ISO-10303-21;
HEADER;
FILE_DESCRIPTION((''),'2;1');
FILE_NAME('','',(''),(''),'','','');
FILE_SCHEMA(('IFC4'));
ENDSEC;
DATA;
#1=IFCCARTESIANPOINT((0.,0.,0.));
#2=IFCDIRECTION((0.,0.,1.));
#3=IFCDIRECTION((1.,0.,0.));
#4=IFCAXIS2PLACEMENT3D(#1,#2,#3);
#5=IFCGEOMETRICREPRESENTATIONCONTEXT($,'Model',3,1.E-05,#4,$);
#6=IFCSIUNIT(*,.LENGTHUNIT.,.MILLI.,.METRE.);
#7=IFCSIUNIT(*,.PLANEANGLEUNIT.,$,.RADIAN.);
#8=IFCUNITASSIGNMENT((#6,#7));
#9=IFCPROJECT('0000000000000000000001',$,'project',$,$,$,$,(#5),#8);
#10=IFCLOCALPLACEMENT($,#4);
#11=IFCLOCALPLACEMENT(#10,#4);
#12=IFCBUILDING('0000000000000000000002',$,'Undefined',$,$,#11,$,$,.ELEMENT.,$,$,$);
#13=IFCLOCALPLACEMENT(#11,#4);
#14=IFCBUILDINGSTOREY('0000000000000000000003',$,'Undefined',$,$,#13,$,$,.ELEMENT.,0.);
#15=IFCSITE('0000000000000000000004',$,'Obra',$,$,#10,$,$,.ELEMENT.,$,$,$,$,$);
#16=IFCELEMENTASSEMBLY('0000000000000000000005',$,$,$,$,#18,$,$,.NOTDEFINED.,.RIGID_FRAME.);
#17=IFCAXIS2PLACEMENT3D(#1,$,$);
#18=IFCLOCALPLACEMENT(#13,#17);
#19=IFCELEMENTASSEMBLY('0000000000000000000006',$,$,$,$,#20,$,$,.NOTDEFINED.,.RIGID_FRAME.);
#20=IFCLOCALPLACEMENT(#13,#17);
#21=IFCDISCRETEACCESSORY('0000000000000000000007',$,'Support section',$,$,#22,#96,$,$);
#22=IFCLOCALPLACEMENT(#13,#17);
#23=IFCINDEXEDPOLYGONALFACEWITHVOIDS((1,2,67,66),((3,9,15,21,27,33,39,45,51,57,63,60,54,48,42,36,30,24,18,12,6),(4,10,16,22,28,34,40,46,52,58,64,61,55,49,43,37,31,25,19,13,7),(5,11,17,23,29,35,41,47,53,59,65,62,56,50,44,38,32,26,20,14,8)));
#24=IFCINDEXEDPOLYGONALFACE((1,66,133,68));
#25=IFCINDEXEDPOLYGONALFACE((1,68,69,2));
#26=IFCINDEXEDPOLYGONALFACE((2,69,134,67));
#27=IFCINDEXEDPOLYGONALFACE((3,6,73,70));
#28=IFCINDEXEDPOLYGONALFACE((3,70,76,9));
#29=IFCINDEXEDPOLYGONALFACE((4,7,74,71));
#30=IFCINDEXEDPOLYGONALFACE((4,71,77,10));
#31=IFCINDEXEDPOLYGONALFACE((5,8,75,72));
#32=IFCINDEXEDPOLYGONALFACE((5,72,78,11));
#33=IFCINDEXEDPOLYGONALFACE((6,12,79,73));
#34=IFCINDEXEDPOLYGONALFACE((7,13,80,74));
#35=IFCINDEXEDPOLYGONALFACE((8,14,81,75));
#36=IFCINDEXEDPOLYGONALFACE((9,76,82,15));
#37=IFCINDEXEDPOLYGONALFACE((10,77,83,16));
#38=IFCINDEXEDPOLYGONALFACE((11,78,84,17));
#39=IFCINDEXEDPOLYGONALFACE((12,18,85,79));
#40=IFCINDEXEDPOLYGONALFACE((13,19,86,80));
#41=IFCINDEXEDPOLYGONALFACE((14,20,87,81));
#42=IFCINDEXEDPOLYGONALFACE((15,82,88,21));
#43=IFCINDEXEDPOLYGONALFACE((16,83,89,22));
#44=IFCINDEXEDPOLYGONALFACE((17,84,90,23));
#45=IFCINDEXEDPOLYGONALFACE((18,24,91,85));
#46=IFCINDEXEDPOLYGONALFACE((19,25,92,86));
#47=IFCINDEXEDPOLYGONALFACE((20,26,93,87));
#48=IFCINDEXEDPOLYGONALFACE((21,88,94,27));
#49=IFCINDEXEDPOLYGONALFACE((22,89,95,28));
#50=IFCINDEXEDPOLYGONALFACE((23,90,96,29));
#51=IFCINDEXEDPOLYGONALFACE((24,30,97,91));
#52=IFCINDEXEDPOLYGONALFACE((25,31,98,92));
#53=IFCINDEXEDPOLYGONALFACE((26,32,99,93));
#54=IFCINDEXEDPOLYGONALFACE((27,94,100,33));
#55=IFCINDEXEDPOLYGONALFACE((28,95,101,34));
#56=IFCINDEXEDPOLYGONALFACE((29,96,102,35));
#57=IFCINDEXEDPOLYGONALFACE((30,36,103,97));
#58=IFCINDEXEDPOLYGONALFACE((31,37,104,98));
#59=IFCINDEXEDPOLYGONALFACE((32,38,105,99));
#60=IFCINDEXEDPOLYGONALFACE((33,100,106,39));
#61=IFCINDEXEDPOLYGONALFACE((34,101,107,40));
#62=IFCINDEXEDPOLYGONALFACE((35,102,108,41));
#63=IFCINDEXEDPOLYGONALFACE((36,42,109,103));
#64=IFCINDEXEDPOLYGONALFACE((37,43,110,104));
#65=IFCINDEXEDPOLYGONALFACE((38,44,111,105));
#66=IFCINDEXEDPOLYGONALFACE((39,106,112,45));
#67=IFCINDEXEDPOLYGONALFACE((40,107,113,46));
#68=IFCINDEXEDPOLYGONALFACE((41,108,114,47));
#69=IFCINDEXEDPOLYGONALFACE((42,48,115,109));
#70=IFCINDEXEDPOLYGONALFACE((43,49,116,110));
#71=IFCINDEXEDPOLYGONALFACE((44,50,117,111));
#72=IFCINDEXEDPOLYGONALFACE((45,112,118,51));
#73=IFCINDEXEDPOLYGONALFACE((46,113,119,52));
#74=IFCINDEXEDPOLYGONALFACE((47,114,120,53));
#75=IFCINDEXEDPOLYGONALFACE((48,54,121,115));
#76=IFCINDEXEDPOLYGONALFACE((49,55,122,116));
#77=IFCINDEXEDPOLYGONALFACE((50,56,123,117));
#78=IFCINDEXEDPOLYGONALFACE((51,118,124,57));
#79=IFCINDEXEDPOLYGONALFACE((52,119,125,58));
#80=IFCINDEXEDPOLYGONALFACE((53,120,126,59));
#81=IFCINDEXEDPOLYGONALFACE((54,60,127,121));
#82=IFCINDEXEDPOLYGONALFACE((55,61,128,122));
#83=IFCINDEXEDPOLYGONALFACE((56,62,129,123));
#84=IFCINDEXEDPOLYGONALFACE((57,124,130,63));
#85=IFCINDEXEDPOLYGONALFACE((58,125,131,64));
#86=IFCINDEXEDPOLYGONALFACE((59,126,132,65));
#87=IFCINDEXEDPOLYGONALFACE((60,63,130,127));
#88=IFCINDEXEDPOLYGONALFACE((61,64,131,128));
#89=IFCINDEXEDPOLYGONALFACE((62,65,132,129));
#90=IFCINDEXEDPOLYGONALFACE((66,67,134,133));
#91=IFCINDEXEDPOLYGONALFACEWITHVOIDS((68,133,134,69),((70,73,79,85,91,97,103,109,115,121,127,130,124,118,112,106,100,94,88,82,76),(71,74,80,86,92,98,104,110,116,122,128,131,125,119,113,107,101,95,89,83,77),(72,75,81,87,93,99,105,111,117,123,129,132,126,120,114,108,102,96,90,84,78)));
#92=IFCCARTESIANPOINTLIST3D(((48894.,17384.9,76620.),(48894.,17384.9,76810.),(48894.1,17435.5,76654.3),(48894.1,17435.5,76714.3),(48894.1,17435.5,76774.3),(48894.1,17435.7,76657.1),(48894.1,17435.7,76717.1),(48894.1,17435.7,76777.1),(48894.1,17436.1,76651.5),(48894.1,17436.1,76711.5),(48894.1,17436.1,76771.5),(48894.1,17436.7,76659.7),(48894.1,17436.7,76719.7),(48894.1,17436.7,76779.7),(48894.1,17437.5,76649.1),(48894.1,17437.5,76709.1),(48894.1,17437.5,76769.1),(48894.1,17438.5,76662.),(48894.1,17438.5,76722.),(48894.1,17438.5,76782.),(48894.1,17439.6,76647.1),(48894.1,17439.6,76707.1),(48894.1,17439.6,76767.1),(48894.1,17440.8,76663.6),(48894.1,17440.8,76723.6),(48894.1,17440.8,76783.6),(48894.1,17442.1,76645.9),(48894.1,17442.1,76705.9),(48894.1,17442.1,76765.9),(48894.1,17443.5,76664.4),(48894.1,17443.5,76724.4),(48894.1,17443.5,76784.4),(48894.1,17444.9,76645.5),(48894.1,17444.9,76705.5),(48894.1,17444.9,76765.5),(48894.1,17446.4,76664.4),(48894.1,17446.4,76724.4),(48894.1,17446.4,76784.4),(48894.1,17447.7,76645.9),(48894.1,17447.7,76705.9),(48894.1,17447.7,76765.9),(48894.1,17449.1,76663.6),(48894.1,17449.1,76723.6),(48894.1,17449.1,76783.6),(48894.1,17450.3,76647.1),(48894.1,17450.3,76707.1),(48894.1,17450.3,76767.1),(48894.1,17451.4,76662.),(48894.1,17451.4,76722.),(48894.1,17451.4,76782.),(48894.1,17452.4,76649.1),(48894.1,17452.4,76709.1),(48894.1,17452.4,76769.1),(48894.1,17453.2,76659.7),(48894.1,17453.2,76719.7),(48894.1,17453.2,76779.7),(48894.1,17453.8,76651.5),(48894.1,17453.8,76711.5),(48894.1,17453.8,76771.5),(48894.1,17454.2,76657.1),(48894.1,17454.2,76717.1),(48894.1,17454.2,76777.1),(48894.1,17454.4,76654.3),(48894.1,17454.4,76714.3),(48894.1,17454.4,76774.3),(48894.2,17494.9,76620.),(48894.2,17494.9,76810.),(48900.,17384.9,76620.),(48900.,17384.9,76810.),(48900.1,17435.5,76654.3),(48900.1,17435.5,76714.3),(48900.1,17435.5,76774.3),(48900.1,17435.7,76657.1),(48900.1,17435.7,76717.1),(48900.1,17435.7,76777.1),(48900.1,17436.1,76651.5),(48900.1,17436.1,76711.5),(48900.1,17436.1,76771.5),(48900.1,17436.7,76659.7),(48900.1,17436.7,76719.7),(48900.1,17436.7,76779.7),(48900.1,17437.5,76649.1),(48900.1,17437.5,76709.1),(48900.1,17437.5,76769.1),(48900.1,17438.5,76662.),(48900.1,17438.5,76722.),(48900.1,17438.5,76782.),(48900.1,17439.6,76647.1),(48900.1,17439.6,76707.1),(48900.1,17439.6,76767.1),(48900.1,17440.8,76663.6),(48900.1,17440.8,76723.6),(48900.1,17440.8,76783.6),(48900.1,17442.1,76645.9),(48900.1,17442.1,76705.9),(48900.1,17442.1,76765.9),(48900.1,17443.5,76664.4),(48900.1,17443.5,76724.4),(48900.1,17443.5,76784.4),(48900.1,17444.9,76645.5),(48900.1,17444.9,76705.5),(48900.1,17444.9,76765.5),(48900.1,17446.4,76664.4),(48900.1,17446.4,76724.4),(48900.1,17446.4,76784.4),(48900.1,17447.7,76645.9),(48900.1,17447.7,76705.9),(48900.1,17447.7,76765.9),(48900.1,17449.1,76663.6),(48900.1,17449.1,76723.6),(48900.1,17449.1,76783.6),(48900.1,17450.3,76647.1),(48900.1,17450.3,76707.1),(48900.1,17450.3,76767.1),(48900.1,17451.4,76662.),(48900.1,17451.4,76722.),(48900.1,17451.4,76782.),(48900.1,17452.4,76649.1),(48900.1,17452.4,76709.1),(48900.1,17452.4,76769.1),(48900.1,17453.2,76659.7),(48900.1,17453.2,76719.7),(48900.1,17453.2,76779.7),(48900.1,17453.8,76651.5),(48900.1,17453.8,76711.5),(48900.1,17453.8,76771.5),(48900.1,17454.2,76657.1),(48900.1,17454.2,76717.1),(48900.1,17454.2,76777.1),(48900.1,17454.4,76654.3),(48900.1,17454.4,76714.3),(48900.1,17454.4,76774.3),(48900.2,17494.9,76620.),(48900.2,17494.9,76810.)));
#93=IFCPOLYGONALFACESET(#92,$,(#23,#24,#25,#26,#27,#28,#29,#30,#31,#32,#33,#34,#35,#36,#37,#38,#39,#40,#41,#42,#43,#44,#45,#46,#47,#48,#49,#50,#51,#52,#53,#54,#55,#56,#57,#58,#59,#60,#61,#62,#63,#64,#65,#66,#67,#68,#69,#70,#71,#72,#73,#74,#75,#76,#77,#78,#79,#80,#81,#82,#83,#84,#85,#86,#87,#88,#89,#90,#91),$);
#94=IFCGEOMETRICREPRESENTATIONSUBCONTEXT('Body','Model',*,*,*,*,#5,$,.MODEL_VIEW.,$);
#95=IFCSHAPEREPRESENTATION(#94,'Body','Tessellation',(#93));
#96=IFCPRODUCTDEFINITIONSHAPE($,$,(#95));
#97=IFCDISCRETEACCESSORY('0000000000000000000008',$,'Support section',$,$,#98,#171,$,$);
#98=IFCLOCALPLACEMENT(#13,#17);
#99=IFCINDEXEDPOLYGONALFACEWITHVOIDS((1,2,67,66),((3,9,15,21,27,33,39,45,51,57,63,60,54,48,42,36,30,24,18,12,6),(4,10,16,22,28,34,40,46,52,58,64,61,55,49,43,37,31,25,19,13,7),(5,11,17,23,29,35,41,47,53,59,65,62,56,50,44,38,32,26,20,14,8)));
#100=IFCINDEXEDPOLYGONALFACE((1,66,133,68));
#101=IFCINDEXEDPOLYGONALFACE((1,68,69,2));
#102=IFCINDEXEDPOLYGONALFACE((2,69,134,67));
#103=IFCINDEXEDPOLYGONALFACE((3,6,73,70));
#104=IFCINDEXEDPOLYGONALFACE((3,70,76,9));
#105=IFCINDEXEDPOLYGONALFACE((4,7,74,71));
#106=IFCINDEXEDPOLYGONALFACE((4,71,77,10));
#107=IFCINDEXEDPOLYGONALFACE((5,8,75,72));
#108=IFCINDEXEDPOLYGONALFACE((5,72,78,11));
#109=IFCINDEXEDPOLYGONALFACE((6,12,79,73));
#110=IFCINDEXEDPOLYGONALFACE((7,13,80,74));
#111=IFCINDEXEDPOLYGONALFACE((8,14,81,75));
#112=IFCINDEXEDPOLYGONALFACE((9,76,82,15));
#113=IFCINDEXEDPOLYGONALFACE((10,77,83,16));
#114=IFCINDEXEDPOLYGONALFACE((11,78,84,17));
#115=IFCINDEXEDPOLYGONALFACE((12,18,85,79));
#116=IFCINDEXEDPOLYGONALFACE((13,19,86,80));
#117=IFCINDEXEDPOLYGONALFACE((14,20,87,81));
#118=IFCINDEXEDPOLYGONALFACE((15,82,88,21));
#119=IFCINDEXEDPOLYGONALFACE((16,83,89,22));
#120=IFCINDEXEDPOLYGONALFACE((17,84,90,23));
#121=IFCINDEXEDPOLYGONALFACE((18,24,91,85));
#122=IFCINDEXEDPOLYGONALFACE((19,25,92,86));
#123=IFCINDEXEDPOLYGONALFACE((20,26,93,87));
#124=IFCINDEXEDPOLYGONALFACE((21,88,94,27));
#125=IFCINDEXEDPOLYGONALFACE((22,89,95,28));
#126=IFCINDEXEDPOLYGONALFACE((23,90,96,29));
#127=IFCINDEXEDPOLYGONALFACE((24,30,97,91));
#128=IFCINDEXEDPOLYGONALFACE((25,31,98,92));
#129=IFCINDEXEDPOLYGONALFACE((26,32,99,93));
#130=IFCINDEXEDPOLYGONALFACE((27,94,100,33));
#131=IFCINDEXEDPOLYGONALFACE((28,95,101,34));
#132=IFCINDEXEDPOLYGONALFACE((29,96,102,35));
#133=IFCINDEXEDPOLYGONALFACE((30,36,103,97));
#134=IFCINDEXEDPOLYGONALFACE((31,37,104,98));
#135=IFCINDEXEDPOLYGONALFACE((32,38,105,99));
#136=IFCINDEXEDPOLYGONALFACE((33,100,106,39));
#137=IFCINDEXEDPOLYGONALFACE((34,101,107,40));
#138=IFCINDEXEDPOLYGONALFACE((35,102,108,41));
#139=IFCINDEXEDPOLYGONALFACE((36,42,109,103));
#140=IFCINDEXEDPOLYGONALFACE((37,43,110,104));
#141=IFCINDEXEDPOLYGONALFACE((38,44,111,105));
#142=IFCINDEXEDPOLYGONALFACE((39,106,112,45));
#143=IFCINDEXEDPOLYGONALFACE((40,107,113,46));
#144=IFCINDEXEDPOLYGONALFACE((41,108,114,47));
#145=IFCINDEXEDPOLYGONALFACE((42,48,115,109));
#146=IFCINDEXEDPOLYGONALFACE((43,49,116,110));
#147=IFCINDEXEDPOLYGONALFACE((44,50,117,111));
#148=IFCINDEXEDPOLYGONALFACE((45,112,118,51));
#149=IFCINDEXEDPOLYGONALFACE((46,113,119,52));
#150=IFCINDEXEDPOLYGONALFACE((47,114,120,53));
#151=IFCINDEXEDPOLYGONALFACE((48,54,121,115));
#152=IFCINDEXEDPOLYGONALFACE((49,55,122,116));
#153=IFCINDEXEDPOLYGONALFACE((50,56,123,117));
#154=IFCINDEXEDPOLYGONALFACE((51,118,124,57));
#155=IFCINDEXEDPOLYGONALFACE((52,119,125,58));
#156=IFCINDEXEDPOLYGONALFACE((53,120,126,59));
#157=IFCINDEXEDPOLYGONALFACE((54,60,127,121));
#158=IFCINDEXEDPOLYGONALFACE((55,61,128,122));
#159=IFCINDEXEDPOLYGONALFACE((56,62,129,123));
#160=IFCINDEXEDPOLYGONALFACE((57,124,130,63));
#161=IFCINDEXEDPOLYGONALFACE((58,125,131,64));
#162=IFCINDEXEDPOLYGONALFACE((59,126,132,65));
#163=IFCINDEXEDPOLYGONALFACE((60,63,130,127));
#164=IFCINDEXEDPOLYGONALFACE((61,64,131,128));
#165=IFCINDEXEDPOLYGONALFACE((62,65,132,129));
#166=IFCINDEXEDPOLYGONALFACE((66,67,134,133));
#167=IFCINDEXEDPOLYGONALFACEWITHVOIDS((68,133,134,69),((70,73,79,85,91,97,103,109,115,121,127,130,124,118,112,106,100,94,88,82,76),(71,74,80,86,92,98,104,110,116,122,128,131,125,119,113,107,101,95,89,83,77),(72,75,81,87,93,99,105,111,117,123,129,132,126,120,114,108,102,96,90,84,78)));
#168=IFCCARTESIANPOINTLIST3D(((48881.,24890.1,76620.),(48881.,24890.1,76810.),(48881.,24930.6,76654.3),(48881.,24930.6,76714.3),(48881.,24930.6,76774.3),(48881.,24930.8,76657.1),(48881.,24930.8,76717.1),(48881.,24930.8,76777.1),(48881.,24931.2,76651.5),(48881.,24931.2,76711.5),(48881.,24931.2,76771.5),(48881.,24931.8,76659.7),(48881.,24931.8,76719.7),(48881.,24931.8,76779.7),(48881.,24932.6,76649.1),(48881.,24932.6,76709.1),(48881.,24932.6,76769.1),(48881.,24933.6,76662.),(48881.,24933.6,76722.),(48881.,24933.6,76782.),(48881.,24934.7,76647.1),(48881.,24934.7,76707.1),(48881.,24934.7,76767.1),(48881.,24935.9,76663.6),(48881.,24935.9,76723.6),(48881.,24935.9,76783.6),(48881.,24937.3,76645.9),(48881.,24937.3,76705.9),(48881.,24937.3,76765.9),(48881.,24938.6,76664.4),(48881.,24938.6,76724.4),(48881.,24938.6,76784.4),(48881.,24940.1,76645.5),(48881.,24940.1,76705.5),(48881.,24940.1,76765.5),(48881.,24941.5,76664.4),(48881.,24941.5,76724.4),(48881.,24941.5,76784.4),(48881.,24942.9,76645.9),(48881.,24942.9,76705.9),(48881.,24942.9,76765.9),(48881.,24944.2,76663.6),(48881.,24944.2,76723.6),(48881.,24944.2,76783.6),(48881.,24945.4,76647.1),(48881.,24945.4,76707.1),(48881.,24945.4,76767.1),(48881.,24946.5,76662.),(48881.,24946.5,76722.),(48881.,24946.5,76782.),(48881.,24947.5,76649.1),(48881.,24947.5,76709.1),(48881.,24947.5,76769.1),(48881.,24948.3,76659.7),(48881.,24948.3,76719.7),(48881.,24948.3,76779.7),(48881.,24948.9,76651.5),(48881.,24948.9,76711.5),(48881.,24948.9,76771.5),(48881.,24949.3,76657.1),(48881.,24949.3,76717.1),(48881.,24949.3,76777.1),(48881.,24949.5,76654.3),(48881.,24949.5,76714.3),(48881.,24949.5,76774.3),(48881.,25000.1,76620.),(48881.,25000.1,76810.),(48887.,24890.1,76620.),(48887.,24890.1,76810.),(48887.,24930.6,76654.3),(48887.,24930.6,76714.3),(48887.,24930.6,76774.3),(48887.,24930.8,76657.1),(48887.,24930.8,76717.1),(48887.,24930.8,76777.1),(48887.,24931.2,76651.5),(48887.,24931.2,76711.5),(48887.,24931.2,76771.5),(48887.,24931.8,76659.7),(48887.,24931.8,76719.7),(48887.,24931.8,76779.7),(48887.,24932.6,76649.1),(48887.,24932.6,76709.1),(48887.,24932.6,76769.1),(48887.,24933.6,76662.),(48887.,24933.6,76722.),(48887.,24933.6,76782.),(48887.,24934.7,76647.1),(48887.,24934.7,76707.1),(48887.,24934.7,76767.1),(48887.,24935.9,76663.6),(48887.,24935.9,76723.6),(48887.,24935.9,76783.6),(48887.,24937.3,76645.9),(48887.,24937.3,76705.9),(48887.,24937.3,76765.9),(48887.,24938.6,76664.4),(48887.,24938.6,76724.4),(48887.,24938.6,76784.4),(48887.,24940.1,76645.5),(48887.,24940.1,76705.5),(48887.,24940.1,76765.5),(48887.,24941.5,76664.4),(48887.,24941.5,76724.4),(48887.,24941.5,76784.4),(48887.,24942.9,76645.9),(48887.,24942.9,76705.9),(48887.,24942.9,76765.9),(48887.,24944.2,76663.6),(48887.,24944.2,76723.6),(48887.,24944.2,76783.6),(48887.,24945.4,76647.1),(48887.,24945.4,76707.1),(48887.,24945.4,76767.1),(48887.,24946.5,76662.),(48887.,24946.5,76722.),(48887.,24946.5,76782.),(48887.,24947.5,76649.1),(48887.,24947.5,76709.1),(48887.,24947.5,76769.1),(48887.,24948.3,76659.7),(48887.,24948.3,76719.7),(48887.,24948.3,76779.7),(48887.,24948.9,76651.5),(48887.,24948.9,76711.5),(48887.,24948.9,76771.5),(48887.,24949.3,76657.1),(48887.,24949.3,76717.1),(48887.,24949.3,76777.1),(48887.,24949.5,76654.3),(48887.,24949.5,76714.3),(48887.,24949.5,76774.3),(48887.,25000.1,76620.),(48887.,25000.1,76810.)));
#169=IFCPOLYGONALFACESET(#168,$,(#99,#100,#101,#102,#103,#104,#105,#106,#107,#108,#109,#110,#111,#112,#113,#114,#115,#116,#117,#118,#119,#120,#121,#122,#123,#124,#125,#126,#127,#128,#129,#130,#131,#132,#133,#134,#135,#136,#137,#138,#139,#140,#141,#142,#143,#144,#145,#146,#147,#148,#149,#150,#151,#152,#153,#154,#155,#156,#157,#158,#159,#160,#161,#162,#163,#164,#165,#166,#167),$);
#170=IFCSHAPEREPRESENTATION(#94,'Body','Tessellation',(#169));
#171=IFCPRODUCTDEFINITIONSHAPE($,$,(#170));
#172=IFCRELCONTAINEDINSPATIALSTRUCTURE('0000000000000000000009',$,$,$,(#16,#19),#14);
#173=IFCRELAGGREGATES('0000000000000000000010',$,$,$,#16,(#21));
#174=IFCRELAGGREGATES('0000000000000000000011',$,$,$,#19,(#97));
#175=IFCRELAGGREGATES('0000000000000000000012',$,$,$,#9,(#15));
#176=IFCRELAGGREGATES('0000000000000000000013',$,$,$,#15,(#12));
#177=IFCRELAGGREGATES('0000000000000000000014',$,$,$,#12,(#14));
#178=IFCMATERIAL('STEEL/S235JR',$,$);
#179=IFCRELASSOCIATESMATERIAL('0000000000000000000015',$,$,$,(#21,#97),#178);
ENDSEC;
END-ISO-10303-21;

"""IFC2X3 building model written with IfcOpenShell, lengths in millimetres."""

from ifc_helpers import new_model, si_unit, frame, origin_with_axes, origin_2d_with_axis, place, context, subcontext, project, spatial, rectangle, circle, extrude, source, transform, mapped, material, element, aggregate, save


model = new_model("IFC2X3")

# Units and contexts
model_context = context("Model", 3, precision=1e-05, world=origin_with_axes())
body_context = subcontext(model_context, "Body", "Model", "MODEL_VIEW")
ifc_project = project(units=[si_unit("LENGTHUNIT", "METRE", prefix="MILLI"), si_unit("PLANEANGLEUNIT", "RADIAN")], contexts=[model_context])

# Site, building, storey
site_placement = place(None, origin_with_axes())
site = spatial("IfcSite", under=ifc_project, at=site_placement, Name="Obra", CompositionType="ELEMENT")
building_placement = place(site_placement, origin_with_axes())
building = spatial("IfcBuilding", under=site, at=building_placement, Name="Undefined", CompositionType="ELEMENT")
storey_placement = place(building_placement, origin_with_axes())
storey = spatial("IfcBuildingStorey", under=building, at=storey_placement, Name="Undefined", CompositionType="ELEMENT", Elevation=0.0)

# Element assemblies
ifc_material_1 = material(Name="STEEL/S235JR")
assembly_1_placement = place(storey_placement, origin_with_axes())
assembly_1 = element("IfcElementAssembly", 1, at=assembly_1_placement, inside=storey, AssemblyPlace="NOTDEFINED", PredefinedType="RIGID_FRAME")
assembly_2_placement = place(storey_placement, origin_with_axes())
assembly_2 = element("IfcElementAssembly", 2, at=assembly_2_placement, inside=storey, AssemblyPlace="NOTDEFINED", PredefinedType="RIGID_FRAME")

# Discrete accessories, openings
shared_shape = source(origin_with_axes(), body_context, "Body", "SweptSolid", [
    extrude(circle(Radius=9.5, at=origin_2d_with_axis()), frame((0.0, -9.2, 0.0), z_axis=(0.0, 1.0, 0.0), x_axis=(1.0, 0.0, 0.0)), (0.0, 0.0, 1.0), 6.2),
])
discrete_accessory_1_placement = place(assembly_1_placement, frame((48897.1, 17439.9, 76620.0), z_axis=(0.0, 0.0, 1.0), x_axis=(-0.001649, -0.999999, 0.0)))
discrete_accessory_1 = element("IfcDiscreteAccessory", 3, at=discrete_accessory_1_placement, material=ifc_material_1, Name="Support section", context=body_context, shape_type="SweptSolid", body=[
    extrude(rectangle(XDim=6.0, YDim=110.0, at=origin_2d_with_axis()), frame((0.0, 0.0, 190.0), z_axis=(0.0, 0.0, -1.0), x_axis=(0.0, 1.0, 0.0)), (0.0, 0.0, 1.0), 190.0),
])
opening_1_placement = place(assembly_1_placement, frame((48890.9, 17395.0, 76835.0), z_axis=(0.001649, 0.999999, 0.0), x_axis=(0.0, 0.0, -1.0)))
element("IfcOpeningElement", 4, at=opening_1_placement, cuts=discrete_accessory_1, ObjectType="Opening", context=body_context, shape_type="MappedRepresentation", body=[
    mapped(shared_shape, transform((60.0, 0.0, 50.0))),
    mapped(shared_shape, transform((120.0, 0.0, 50.0))),
    mapped(shared_shape, transform((180.0, 0.0, 50.0))),
])
aggregate(assembly_1, [discrete_accessory_1])
discrete_accessory_2_placement = place(assembly_2_placement, frame((48884.0, 24945.1, 76620.0), z_axis=(0.0, 0.0, 1.0), x_axis=(-0.000002, 1.0, 0.0)))
discrete_accessory_2 = element("IfcDiscreteAccessory", 5, at=discrete_accessory_2_placement, material=ifc_material_1, Name="Support section", context=body_context, shape_type="SweptSolid", body=[
    extrude(rectangle(XDim=6.0, YDim=110.0, at=origin_2d_with_axis()), frame((0.0, 0.0, 190.0), z_axis=(0.0, 0.0, -1.0), x_axis=(0.0, 1.0, 0.0)), (0.0, 0.0, 1.0), 190.0),
])
opening_2_placement = place(assembly_2_placement, frame((48890.1, 24990.1, 76835.0), z_axis=(0.000002, -1.0, 0.0), x_axis=(0.0, 0.0, -1.0)))
element("IfcOpeningElement", 6, at=opening_2_placement, cuts=discrete_accessory_2, ObjectType="Opening", context=body_context, shape_type="MappedRepresentation", body=[
    mapped(shared_shape, transform((60.0, 0.0, 50.0))),
    mapped(shared_shape, transform((120.0, 0.0, 50.0))),
    mapped(shared_shape, transform((180.0, 0.0, 50.0))),
])
aggregate(assembly_2, [discrete_accessory_2])

save(model, "model.ifc")
